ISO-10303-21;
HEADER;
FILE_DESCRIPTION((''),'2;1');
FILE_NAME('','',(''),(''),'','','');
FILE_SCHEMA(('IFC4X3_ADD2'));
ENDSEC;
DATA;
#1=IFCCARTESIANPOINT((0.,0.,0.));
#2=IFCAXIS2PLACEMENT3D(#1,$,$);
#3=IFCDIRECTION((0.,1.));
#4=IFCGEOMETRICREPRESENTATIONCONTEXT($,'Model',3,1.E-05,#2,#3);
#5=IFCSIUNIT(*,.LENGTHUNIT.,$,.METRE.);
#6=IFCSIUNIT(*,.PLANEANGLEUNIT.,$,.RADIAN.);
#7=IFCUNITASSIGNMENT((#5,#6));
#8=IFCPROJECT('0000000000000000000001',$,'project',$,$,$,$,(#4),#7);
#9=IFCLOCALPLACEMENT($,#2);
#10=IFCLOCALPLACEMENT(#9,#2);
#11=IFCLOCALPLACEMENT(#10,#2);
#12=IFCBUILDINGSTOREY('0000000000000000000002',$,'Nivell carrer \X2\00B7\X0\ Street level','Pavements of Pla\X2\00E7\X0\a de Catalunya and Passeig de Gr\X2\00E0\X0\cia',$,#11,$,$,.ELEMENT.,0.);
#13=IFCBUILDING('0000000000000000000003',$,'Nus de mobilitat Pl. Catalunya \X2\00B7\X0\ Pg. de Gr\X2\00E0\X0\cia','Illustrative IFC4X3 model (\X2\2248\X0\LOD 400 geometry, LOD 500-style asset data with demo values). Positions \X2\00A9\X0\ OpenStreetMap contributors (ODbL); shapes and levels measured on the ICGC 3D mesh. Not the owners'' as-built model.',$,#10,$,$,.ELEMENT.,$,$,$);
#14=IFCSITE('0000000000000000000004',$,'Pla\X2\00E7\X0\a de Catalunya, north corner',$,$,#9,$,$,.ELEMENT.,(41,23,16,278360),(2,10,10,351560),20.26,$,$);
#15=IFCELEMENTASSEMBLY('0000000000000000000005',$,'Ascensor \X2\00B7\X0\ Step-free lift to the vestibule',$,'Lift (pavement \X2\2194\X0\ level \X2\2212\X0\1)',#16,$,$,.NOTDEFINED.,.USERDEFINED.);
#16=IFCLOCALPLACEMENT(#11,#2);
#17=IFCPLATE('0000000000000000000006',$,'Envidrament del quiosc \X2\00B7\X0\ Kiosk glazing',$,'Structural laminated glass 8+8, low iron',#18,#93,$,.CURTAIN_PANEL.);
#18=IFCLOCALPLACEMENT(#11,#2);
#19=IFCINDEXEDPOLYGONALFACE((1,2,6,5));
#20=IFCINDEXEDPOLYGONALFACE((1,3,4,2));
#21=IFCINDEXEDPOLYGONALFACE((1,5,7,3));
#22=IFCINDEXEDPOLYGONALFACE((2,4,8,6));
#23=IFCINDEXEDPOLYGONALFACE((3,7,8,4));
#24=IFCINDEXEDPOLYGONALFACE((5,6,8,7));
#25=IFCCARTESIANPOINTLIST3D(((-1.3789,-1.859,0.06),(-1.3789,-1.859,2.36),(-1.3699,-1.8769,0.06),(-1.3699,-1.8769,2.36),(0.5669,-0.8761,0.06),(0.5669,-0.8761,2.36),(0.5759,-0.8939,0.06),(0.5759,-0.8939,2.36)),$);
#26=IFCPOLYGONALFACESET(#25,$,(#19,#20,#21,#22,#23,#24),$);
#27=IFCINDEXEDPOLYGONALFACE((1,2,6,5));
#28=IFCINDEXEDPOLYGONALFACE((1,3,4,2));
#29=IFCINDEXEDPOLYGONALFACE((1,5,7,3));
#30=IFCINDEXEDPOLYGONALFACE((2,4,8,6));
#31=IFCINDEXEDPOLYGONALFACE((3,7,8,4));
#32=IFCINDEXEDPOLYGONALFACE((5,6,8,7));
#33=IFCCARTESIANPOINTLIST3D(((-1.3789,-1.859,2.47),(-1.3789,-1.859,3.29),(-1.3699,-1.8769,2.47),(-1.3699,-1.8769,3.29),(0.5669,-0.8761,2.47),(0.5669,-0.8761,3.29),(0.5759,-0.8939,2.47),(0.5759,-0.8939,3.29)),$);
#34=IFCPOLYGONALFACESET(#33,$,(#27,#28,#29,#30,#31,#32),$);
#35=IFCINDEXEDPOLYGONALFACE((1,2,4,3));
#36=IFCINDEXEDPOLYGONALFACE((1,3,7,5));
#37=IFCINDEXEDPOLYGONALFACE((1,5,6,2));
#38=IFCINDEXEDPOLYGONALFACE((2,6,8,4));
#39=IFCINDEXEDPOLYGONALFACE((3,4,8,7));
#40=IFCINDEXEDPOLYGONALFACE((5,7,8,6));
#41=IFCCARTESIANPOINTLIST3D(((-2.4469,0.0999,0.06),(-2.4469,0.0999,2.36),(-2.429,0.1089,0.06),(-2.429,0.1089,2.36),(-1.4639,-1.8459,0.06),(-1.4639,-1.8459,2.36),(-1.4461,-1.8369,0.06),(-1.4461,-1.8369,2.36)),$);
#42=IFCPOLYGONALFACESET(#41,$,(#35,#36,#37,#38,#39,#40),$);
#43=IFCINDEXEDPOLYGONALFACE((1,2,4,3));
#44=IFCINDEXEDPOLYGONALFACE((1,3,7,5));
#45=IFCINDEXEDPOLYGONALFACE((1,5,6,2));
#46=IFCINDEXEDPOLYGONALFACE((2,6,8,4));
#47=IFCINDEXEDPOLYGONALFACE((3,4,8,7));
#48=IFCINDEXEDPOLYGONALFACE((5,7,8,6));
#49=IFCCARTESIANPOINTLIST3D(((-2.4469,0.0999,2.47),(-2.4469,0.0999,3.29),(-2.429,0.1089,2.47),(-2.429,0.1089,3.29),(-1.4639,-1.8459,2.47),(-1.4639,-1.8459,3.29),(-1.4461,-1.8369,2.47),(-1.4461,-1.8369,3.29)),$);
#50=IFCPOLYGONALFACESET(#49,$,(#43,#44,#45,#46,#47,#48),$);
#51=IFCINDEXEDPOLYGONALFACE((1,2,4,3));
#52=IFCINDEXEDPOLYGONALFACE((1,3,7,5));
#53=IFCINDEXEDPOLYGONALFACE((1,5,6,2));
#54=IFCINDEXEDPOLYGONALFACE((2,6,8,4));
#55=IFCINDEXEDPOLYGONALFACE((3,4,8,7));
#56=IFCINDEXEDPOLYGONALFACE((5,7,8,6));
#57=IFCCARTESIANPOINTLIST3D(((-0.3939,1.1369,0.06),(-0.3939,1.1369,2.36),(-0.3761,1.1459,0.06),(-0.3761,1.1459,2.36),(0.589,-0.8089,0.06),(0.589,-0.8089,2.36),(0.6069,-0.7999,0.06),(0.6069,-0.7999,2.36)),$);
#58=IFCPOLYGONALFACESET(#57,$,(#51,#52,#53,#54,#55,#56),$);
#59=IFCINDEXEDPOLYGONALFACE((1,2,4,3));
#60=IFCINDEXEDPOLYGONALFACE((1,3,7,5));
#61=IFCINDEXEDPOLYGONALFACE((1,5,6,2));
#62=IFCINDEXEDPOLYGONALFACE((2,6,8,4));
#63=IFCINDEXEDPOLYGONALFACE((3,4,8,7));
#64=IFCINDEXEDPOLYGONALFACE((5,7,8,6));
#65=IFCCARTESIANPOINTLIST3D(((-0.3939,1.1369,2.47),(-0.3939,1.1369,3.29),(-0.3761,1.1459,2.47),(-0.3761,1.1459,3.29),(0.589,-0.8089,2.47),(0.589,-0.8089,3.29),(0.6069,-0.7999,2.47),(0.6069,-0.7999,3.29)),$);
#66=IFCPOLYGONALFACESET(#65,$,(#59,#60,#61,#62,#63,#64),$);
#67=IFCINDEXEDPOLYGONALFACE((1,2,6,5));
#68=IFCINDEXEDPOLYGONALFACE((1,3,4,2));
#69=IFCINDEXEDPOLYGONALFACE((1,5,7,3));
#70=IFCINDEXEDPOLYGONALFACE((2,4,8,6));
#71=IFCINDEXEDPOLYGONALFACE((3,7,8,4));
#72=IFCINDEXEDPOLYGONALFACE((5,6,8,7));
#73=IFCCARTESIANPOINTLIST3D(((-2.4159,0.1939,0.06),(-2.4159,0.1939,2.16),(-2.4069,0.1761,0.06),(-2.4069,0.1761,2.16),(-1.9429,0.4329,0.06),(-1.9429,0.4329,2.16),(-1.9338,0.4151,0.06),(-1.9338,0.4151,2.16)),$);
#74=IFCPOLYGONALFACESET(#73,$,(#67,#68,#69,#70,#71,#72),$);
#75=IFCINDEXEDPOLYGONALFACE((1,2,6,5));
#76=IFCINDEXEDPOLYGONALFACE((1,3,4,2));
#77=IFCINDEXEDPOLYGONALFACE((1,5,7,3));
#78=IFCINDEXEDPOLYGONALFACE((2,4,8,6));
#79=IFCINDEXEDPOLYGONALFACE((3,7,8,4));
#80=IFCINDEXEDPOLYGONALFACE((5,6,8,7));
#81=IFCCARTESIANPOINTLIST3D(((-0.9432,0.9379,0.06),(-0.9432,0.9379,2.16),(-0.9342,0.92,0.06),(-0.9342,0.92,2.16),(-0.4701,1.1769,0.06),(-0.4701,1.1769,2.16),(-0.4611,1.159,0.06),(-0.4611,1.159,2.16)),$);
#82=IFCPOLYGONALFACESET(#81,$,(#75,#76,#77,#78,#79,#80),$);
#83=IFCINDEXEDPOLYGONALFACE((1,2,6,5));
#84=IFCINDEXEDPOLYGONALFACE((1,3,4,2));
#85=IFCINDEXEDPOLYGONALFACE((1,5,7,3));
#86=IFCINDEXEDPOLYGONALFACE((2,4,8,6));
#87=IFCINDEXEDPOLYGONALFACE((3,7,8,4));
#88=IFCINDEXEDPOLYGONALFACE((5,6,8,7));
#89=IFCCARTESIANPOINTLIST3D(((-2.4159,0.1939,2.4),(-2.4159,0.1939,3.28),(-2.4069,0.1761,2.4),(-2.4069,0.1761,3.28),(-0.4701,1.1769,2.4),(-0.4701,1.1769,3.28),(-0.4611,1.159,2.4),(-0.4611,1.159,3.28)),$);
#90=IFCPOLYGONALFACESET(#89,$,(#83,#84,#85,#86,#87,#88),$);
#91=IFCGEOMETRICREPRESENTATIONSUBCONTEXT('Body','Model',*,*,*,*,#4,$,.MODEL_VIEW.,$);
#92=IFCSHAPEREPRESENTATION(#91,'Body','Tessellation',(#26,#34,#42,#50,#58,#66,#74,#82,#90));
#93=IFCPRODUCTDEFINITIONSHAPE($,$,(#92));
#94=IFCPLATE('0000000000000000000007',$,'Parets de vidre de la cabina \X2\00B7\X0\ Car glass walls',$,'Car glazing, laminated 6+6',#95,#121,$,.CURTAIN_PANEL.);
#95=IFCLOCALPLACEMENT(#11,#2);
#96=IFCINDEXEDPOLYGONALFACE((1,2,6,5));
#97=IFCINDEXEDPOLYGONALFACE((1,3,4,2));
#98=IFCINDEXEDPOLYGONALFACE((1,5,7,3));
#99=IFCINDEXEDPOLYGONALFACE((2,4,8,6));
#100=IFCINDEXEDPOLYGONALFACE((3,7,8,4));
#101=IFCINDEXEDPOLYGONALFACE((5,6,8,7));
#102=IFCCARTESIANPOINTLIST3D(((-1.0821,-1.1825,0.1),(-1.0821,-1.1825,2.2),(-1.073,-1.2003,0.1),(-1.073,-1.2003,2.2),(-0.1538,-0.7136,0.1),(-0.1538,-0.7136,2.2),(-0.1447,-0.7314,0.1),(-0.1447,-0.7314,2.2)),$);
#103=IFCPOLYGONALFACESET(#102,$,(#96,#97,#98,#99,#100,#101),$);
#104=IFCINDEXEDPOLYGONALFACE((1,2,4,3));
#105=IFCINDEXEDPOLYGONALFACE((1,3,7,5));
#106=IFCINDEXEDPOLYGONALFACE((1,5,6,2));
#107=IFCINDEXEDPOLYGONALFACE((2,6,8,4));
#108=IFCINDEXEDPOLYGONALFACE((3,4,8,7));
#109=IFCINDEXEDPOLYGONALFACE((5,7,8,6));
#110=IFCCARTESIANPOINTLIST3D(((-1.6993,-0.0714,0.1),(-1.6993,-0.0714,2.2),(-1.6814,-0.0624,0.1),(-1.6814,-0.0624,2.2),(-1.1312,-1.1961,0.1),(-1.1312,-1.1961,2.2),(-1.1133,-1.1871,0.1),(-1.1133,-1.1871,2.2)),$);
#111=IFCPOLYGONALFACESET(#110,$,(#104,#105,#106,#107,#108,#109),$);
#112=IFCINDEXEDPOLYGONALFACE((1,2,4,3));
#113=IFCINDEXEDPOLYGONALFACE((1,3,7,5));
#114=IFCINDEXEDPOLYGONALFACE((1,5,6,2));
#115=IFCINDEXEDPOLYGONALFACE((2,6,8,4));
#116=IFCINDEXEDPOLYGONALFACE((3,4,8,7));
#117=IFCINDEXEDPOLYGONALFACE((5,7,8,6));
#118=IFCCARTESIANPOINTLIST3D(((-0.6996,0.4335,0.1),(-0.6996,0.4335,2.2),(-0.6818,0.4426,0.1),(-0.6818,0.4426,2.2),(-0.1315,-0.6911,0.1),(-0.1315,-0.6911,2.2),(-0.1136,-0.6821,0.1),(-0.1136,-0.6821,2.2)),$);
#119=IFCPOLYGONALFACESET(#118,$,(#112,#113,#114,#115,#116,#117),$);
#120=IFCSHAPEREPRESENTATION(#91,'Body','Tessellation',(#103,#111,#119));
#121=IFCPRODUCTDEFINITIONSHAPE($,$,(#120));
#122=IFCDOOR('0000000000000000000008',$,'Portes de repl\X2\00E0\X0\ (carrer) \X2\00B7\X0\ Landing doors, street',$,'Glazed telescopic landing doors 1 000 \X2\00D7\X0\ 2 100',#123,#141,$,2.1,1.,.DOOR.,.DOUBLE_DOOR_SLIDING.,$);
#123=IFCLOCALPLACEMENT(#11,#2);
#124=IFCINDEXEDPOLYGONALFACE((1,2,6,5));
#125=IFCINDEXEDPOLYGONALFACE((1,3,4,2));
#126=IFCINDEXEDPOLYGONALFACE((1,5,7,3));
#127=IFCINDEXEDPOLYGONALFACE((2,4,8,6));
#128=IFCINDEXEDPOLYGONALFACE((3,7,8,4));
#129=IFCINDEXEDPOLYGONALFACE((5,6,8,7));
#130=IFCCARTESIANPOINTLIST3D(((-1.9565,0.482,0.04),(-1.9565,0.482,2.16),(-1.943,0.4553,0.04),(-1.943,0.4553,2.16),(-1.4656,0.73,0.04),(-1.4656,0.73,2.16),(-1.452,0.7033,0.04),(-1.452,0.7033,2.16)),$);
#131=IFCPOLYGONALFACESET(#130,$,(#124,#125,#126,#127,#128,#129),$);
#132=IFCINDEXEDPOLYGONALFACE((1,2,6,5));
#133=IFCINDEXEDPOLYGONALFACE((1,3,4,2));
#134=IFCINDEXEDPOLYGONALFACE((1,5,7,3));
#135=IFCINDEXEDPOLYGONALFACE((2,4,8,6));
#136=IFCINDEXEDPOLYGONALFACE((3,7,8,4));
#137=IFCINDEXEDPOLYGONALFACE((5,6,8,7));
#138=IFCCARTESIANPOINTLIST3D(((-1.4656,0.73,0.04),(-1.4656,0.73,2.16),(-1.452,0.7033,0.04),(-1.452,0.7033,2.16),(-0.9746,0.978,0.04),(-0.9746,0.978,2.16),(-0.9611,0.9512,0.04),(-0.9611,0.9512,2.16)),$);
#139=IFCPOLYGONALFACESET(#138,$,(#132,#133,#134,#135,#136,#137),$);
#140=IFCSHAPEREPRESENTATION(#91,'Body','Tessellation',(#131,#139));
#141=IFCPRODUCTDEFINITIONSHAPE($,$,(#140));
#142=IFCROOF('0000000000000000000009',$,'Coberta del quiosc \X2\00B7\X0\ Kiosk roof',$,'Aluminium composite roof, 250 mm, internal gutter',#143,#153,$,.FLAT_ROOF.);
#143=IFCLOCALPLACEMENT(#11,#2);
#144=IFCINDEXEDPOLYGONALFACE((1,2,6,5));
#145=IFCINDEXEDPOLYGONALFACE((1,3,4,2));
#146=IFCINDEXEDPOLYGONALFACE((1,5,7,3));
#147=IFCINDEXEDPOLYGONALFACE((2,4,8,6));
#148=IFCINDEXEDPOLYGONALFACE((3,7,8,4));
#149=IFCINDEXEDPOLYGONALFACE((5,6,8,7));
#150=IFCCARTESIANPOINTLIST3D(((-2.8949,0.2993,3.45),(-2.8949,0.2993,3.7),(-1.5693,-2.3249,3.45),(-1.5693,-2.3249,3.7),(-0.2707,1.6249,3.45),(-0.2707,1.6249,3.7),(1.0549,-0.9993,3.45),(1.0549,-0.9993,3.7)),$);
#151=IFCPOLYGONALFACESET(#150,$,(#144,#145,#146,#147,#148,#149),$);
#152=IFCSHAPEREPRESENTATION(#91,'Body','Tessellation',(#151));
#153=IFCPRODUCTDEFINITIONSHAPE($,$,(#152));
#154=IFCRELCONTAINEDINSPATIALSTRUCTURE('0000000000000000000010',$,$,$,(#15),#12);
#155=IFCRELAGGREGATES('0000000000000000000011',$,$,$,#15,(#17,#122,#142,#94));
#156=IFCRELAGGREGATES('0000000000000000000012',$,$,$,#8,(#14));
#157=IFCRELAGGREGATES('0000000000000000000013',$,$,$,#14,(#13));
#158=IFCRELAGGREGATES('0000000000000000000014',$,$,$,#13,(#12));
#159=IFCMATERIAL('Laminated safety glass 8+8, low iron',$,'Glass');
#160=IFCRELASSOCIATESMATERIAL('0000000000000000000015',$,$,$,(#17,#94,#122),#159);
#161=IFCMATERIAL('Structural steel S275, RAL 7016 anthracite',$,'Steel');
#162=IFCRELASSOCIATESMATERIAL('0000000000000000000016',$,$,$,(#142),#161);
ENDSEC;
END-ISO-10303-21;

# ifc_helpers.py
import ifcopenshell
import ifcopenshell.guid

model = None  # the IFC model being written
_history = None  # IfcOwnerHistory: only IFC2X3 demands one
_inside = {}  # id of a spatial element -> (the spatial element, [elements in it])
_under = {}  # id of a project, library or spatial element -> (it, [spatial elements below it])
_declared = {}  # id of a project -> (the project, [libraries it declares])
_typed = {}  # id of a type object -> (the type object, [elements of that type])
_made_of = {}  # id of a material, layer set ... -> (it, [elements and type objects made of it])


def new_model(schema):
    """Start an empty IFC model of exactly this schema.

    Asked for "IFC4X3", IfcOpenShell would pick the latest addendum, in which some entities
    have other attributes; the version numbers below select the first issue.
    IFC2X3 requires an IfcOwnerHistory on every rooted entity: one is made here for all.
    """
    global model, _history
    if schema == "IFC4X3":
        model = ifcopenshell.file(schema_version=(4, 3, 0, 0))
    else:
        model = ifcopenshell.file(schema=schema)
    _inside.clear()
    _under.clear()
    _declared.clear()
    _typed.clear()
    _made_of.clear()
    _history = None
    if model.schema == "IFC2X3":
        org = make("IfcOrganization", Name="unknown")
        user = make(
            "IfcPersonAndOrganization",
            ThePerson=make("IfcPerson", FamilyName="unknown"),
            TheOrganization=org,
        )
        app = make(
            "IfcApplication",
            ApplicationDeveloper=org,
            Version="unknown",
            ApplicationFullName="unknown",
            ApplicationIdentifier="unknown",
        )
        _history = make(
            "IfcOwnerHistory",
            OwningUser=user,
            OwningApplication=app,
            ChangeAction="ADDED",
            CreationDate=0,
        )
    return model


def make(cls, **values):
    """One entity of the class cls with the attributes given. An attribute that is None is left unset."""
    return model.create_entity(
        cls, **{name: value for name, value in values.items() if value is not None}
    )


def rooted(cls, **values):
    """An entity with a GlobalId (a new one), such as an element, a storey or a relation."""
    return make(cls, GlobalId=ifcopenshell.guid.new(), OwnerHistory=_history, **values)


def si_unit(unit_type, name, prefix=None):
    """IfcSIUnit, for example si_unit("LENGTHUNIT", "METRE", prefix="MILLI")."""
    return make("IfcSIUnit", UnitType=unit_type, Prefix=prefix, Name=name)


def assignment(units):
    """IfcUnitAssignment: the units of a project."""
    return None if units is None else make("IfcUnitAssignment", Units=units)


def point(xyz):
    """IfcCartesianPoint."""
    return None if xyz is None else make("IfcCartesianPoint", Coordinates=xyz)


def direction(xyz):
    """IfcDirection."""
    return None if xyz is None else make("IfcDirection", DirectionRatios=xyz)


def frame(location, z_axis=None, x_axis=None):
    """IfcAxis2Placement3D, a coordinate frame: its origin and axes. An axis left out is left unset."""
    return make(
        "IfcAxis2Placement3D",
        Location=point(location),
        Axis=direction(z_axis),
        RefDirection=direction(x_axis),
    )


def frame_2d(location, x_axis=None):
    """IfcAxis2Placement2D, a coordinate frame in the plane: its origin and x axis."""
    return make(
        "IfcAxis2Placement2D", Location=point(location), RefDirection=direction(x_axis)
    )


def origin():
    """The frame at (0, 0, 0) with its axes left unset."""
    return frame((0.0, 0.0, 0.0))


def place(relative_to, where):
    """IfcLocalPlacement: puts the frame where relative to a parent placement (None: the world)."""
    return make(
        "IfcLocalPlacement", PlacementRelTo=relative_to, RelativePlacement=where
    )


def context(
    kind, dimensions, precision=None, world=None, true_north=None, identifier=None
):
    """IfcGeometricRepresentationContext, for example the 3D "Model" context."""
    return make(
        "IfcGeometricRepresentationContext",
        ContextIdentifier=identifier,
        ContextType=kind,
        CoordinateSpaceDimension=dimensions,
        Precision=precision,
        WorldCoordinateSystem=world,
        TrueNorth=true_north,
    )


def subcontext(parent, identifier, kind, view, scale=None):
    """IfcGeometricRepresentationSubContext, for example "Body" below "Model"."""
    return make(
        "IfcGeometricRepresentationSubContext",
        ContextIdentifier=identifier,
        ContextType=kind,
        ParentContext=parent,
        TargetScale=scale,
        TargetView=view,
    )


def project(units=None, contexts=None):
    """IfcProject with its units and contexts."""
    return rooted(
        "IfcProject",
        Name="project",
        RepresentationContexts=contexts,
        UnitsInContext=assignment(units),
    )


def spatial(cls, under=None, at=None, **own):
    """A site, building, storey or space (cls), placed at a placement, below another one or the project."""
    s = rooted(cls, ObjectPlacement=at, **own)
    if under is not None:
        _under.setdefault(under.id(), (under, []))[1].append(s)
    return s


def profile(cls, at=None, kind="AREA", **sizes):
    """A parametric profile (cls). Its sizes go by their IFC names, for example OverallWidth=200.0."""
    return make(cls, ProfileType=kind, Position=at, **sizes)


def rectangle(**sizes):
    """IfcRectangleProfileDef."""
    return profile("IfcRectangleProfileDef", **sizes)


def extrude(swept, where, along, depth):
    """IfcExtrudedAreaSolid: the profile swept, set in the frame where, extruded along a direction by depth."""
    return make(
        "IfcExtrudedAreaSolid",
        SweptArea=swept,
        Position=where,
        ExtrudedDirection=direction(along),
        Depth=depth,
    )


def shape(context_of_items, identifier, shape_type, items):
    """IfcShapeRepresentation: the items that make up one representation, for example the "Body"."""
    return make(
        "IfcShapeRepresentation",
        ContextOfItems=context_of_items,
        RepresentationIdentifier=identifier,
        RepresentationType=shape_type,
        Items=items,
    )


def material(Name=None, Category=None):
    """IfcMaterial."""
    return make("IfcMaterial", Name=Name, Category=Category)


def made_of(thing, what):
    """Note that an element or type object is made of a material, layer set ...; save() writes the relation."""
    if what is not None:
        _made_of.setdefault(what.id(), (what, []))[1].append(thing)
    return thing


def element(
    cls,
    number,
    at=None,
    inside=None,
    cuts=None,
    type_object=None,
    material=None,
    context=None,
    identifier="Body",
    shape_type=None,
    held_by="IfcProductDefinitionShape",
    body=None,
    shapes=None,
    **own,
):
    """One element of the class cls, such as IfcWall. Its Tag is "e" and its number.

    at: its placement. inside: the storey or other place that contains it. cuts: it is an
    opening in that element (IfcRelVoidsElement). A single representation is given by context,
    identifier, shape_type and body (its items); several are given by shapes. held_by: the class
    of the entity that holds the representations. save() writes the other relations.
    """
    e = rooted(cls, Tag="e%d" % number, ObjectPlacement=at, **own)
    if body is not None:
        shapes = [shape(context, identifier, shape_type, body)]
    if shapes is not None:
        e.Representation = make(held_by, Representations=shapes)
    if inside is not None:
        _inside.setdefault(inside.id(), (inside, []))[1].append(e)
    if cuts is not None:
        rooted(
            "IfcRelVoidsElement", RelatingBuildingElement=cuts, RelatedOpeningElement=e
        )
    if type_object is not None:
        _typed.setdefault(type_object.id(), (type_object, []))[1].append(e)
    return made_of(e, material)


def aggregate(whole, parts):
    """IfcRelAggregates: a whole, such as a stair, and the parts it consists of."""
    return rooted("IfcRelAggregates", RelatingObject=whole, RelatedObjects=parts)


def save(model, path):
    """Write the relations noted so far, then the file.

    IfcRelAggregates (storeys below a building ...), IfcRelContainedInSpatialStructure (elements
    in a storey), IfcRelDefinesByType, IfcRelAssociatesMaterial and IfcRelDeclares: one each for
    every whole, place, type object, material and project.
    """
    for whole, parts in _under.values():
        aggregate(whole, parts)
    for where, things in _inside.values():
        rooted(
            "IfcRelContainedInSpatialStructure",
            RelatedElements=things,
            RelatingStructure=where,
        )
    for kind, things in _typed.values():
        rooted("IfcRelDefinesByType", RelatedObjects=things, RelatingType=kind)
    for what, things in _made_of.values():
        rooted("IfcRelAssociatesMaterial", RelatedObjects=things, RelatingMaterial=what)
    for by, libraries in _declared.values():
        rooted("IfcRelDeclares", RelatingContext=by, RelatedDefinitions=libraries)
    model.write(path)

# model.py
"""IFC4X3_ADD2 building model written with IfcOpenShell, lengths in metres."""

from ifc_helpers import new_model, si_unit, direction, frame, frame_2d, origin, place, context, subcontext, project, spatial, rectangle, extrude, material, element, aggregate, save


model = new_model("IFC4X3_ADD2")

# Units and contexts
model_context = context("Model", 3, precision=1e-05, world=origin(), true_north=direction((0.0, 1.0)))
body_context = subcontext(model_context, "Body", "Model", "MODEL_VIEW")
ifc_project = project(units=[si_unit("LENGTHUNIT", "METRE"), si_unit("PLANEANGLEUNIT", "RADIAN")], contexts=[model_context])

# Site, building, storey
site_placement = place(None, origin())
site = spatial("IfcSite", under=ifc_project, at=site_placement, Name="Plaça de Catalunya, north corner", CompositionType="ELEMENT", RefLatitude=(41, 23, 16, 278360), RefLongitude=(2, 10, 10, 351560), RefElevation=20.26)
building_placement = place(site_placement, origin())
building = spatial("IfcBuilding", under=site, at=building_placement, Name="Nus de mobilitat Pl. Catalunya · Pg. de Gràcia", Description="Illustrative IFC4X3 model (≈LOD 400 geometry, LOD 500-style asset data with demo values). Positions © OpenStreetMap contributors (ODbL); shapes and levels measured on the ICGC 3D mesh. Not the owners' as-built model.", CompositionType="ELEMENT")
storey_placement = place(building_placement, origin())
storey = spatial("IfcBuildingStorey", under=building, at=storey_placement, Name="Nivell carrer · Street level", Description="Pavements of Plaça de Catalunya and Passeig de Gràcia", CompositionType="ELEMENT", Elevation=0.0)

# Element assembly
assembly_1_placement = place(building_placement, origin())
assembly_1 = element("IfcElementAssembly", 1, at=assembly_1_placement, inside=storey, Name="Ascensor · Step-free lift to the vestibule", ObjectType="Lift (pavement ↔ level −1)", AssemblyPlace="NOTDEFINED", PredefinedType="USERDEFINED")
ifc_material_1 = material(Name="Structural steel S275, RAL 7016 anthracite", Category="Steel")

# Plates
ifc_material_2 = material(Name="Laminated safety glass 8+8, low iron", Category="Glass")
plate_1_placement = place(building_placement, origin())
plate_1 = element("IfcPlate", 2, at=plate_1_placement, material=ifc_material_2, Name="Envidrament del quiosc · Kiosk glazing", ObjectType="Structural laminated glass 8+8, low iron", PredefinedType="CURTAIN_PANEL", context=body_context, shape_type="SweptSolid", body=[
    extrude(rectangle(XDim=2.18, YDim=0.02, at=frame_2d((0.0, 0.0), x_axis=(0.892586, 0.450878))), frame((-0.4015, -1.3765, 0.06)), (0.0, 0.0, 1.0), 2.3),
    extrude(rectangle(XDim=2.18, YDim=0.02, at=frame_2d((0.0, 0.0), x_axis=(0.892586, 0.450878))), frame((-0.4015, -1.3765, 2.47)), (0.0, 0.0, 1.0), 0.82),
    extrude(rectangle(XDim=0.02, YDim=2.18, at=frame_2d((0.0, 0.0), x_axis=(0.892586, 0.450878))), frame((-1.9465, -0.8685, 0.06)), (0.0, 0.0, 1.0), 2.3),
    extrude(rectangle(XDim=0.02, YDim=2.18, at=frame_2d((0.0, 0.0), x_axis=(0.892586, 0.450878))), frame((-1.9465, -0.8685, 2.47)), (0.0, 0.0, 1.0), 0.82),
    extrude(rectangle(XDim=0.02, YDim=2.18, at=frame_2d((0.0, 0.0), x_axis=(0.892586, 0.450878))), frame((0.1065, 0.1685, 0.06)), (0.0, 0.0, 1.0), 2.3),
    extrude(rectangle(XDim=0.02, YDim=2.18, at=frame_2d((0.0, 0.0), x_axis=(0.892586, 0.450878))), frame((0.1065, 0.1685, 2.47)), (0.0, 0.0, 1.0), 0.82),
    extrude(rectangle(XDim=0.53, YDim=0.02, at=frame_2d((0.0, 0.0), x_axis=(0.892586, 0.450878))), frame((-2.1749, 0.3045, 0.06)), (0.0, 0.0, 1.0), 2.1),
    extrude(rectangle(XDim=0.53, YDim=0.02, at=frame_2d((0.0, 0.0), x_axis=(0.892586, 0.450878))), frame((-0.7021, 1.0484, 0.06)), (0.0, 0.0, 1.0), 2.1),
    extrude(rectangle(XDim=2.18, YDim=0.02, at=frame_2d((0.0, 0.0), x_axis=(0.892586, 0.450878))), frame((-1.4385, 0.6765, 2.4)), (0.0, 0.0, 1.0), 0.88),
])
plate_2_placement = place(building_placement, origin())
plate_2 = element("IfcPlate", 3, at=plate_2_placement, material=ifc_material_2, Name="Parets de vidre de la cabina · Car glass walls", ObjectType="Car glazing, laminated 6+6", PredefinedType="CURTAIN_PANEL", context=body_context, shape_type="SweptSolid", body=[
    extrude(rectangle(XDim=1.04, YDim=0.02, at=frame_2d((0.0, 0.0), x_axis=(0.892586, 0.450878))), frame((-0.6134, -0.957, 0.1)), (0.0, 0.0, 1.0), 2.1),
    extrude(rectangle(XDim=0.02, YDim=1.26, at=frame_2d((0.0, 0.0), x_axis=(0.892586, 0.450878))), frame((-1.4063, -0.6293, 0.1)), (0.0, 0.0, 1.0), 2.1),
    extrude(rectangle(XDim=0.02, YDim=1.26, at=frame_2d((0.0, 0.0), x_axis=(0.892586, 0.450878))), frame((-0.4066, -0.1243, 0.1)), (0.0, 0.0, 1.0), 2.1),
])

# Door
door_placement = place(building_placement, origin())
door = element("IfcDoor", 4, at=door_placement, material=ifc_material_2, Name="Portes de replà (carrer) · Landing doors, street", ObjectType="Glazed telescopic landing doors 1 000 × 2 100", OperationType="DOUBLE_DOOR_SLIDING", OverallHeight=2.1, OverallWidth=1.0, PredefinedType="DOOR", context=body_context, shape_type="SweptSolid", body=[
    extrude(rectangle(XDim=0.55, YDim=0.03, at=frame_2d((0.0, 0.0), x_axis=(0.892586, 0.450878))), frame((-1.7043, 0.5926, 0.04)), (0.0, 0.0, 1.0), 2.12),
    extrude(rectangle(XDim=0.55, YDim=0.03, at=frame_2d((0.0, 0.0), x_axis=(0.892586, 0.450878))), frame((-1.2133, 0.8406, 0.04)), (0.0, 0.0, 1.0), 2.12),
])

# Roof
roof_placement = place(building_placement, origin())
roof = element("IfcRoof", 5, at=roof_placement, material=ifc_material_1, Name="Coberta del quiosc · Kiosk roof", ObjectType="Aluminium composite roof, 250 mm, internal gutter", PredefinedType="FLAT_ROOF", context=body_context, shape_type="SweptSolid", body=[
    extrude(rectangle(XDim=2.94, YDim=2.94, at=frame_2d((0.0, 0.0), x_axis=(0.892586, 0.450878))), frame((-0.92, -0.35, 3.45)), (0.0, 0.0, 1.0), 0.25),
])

aggregate(assembly_1, [plate_1, door, roof, plate_2])

save(model, "model.ifc")
